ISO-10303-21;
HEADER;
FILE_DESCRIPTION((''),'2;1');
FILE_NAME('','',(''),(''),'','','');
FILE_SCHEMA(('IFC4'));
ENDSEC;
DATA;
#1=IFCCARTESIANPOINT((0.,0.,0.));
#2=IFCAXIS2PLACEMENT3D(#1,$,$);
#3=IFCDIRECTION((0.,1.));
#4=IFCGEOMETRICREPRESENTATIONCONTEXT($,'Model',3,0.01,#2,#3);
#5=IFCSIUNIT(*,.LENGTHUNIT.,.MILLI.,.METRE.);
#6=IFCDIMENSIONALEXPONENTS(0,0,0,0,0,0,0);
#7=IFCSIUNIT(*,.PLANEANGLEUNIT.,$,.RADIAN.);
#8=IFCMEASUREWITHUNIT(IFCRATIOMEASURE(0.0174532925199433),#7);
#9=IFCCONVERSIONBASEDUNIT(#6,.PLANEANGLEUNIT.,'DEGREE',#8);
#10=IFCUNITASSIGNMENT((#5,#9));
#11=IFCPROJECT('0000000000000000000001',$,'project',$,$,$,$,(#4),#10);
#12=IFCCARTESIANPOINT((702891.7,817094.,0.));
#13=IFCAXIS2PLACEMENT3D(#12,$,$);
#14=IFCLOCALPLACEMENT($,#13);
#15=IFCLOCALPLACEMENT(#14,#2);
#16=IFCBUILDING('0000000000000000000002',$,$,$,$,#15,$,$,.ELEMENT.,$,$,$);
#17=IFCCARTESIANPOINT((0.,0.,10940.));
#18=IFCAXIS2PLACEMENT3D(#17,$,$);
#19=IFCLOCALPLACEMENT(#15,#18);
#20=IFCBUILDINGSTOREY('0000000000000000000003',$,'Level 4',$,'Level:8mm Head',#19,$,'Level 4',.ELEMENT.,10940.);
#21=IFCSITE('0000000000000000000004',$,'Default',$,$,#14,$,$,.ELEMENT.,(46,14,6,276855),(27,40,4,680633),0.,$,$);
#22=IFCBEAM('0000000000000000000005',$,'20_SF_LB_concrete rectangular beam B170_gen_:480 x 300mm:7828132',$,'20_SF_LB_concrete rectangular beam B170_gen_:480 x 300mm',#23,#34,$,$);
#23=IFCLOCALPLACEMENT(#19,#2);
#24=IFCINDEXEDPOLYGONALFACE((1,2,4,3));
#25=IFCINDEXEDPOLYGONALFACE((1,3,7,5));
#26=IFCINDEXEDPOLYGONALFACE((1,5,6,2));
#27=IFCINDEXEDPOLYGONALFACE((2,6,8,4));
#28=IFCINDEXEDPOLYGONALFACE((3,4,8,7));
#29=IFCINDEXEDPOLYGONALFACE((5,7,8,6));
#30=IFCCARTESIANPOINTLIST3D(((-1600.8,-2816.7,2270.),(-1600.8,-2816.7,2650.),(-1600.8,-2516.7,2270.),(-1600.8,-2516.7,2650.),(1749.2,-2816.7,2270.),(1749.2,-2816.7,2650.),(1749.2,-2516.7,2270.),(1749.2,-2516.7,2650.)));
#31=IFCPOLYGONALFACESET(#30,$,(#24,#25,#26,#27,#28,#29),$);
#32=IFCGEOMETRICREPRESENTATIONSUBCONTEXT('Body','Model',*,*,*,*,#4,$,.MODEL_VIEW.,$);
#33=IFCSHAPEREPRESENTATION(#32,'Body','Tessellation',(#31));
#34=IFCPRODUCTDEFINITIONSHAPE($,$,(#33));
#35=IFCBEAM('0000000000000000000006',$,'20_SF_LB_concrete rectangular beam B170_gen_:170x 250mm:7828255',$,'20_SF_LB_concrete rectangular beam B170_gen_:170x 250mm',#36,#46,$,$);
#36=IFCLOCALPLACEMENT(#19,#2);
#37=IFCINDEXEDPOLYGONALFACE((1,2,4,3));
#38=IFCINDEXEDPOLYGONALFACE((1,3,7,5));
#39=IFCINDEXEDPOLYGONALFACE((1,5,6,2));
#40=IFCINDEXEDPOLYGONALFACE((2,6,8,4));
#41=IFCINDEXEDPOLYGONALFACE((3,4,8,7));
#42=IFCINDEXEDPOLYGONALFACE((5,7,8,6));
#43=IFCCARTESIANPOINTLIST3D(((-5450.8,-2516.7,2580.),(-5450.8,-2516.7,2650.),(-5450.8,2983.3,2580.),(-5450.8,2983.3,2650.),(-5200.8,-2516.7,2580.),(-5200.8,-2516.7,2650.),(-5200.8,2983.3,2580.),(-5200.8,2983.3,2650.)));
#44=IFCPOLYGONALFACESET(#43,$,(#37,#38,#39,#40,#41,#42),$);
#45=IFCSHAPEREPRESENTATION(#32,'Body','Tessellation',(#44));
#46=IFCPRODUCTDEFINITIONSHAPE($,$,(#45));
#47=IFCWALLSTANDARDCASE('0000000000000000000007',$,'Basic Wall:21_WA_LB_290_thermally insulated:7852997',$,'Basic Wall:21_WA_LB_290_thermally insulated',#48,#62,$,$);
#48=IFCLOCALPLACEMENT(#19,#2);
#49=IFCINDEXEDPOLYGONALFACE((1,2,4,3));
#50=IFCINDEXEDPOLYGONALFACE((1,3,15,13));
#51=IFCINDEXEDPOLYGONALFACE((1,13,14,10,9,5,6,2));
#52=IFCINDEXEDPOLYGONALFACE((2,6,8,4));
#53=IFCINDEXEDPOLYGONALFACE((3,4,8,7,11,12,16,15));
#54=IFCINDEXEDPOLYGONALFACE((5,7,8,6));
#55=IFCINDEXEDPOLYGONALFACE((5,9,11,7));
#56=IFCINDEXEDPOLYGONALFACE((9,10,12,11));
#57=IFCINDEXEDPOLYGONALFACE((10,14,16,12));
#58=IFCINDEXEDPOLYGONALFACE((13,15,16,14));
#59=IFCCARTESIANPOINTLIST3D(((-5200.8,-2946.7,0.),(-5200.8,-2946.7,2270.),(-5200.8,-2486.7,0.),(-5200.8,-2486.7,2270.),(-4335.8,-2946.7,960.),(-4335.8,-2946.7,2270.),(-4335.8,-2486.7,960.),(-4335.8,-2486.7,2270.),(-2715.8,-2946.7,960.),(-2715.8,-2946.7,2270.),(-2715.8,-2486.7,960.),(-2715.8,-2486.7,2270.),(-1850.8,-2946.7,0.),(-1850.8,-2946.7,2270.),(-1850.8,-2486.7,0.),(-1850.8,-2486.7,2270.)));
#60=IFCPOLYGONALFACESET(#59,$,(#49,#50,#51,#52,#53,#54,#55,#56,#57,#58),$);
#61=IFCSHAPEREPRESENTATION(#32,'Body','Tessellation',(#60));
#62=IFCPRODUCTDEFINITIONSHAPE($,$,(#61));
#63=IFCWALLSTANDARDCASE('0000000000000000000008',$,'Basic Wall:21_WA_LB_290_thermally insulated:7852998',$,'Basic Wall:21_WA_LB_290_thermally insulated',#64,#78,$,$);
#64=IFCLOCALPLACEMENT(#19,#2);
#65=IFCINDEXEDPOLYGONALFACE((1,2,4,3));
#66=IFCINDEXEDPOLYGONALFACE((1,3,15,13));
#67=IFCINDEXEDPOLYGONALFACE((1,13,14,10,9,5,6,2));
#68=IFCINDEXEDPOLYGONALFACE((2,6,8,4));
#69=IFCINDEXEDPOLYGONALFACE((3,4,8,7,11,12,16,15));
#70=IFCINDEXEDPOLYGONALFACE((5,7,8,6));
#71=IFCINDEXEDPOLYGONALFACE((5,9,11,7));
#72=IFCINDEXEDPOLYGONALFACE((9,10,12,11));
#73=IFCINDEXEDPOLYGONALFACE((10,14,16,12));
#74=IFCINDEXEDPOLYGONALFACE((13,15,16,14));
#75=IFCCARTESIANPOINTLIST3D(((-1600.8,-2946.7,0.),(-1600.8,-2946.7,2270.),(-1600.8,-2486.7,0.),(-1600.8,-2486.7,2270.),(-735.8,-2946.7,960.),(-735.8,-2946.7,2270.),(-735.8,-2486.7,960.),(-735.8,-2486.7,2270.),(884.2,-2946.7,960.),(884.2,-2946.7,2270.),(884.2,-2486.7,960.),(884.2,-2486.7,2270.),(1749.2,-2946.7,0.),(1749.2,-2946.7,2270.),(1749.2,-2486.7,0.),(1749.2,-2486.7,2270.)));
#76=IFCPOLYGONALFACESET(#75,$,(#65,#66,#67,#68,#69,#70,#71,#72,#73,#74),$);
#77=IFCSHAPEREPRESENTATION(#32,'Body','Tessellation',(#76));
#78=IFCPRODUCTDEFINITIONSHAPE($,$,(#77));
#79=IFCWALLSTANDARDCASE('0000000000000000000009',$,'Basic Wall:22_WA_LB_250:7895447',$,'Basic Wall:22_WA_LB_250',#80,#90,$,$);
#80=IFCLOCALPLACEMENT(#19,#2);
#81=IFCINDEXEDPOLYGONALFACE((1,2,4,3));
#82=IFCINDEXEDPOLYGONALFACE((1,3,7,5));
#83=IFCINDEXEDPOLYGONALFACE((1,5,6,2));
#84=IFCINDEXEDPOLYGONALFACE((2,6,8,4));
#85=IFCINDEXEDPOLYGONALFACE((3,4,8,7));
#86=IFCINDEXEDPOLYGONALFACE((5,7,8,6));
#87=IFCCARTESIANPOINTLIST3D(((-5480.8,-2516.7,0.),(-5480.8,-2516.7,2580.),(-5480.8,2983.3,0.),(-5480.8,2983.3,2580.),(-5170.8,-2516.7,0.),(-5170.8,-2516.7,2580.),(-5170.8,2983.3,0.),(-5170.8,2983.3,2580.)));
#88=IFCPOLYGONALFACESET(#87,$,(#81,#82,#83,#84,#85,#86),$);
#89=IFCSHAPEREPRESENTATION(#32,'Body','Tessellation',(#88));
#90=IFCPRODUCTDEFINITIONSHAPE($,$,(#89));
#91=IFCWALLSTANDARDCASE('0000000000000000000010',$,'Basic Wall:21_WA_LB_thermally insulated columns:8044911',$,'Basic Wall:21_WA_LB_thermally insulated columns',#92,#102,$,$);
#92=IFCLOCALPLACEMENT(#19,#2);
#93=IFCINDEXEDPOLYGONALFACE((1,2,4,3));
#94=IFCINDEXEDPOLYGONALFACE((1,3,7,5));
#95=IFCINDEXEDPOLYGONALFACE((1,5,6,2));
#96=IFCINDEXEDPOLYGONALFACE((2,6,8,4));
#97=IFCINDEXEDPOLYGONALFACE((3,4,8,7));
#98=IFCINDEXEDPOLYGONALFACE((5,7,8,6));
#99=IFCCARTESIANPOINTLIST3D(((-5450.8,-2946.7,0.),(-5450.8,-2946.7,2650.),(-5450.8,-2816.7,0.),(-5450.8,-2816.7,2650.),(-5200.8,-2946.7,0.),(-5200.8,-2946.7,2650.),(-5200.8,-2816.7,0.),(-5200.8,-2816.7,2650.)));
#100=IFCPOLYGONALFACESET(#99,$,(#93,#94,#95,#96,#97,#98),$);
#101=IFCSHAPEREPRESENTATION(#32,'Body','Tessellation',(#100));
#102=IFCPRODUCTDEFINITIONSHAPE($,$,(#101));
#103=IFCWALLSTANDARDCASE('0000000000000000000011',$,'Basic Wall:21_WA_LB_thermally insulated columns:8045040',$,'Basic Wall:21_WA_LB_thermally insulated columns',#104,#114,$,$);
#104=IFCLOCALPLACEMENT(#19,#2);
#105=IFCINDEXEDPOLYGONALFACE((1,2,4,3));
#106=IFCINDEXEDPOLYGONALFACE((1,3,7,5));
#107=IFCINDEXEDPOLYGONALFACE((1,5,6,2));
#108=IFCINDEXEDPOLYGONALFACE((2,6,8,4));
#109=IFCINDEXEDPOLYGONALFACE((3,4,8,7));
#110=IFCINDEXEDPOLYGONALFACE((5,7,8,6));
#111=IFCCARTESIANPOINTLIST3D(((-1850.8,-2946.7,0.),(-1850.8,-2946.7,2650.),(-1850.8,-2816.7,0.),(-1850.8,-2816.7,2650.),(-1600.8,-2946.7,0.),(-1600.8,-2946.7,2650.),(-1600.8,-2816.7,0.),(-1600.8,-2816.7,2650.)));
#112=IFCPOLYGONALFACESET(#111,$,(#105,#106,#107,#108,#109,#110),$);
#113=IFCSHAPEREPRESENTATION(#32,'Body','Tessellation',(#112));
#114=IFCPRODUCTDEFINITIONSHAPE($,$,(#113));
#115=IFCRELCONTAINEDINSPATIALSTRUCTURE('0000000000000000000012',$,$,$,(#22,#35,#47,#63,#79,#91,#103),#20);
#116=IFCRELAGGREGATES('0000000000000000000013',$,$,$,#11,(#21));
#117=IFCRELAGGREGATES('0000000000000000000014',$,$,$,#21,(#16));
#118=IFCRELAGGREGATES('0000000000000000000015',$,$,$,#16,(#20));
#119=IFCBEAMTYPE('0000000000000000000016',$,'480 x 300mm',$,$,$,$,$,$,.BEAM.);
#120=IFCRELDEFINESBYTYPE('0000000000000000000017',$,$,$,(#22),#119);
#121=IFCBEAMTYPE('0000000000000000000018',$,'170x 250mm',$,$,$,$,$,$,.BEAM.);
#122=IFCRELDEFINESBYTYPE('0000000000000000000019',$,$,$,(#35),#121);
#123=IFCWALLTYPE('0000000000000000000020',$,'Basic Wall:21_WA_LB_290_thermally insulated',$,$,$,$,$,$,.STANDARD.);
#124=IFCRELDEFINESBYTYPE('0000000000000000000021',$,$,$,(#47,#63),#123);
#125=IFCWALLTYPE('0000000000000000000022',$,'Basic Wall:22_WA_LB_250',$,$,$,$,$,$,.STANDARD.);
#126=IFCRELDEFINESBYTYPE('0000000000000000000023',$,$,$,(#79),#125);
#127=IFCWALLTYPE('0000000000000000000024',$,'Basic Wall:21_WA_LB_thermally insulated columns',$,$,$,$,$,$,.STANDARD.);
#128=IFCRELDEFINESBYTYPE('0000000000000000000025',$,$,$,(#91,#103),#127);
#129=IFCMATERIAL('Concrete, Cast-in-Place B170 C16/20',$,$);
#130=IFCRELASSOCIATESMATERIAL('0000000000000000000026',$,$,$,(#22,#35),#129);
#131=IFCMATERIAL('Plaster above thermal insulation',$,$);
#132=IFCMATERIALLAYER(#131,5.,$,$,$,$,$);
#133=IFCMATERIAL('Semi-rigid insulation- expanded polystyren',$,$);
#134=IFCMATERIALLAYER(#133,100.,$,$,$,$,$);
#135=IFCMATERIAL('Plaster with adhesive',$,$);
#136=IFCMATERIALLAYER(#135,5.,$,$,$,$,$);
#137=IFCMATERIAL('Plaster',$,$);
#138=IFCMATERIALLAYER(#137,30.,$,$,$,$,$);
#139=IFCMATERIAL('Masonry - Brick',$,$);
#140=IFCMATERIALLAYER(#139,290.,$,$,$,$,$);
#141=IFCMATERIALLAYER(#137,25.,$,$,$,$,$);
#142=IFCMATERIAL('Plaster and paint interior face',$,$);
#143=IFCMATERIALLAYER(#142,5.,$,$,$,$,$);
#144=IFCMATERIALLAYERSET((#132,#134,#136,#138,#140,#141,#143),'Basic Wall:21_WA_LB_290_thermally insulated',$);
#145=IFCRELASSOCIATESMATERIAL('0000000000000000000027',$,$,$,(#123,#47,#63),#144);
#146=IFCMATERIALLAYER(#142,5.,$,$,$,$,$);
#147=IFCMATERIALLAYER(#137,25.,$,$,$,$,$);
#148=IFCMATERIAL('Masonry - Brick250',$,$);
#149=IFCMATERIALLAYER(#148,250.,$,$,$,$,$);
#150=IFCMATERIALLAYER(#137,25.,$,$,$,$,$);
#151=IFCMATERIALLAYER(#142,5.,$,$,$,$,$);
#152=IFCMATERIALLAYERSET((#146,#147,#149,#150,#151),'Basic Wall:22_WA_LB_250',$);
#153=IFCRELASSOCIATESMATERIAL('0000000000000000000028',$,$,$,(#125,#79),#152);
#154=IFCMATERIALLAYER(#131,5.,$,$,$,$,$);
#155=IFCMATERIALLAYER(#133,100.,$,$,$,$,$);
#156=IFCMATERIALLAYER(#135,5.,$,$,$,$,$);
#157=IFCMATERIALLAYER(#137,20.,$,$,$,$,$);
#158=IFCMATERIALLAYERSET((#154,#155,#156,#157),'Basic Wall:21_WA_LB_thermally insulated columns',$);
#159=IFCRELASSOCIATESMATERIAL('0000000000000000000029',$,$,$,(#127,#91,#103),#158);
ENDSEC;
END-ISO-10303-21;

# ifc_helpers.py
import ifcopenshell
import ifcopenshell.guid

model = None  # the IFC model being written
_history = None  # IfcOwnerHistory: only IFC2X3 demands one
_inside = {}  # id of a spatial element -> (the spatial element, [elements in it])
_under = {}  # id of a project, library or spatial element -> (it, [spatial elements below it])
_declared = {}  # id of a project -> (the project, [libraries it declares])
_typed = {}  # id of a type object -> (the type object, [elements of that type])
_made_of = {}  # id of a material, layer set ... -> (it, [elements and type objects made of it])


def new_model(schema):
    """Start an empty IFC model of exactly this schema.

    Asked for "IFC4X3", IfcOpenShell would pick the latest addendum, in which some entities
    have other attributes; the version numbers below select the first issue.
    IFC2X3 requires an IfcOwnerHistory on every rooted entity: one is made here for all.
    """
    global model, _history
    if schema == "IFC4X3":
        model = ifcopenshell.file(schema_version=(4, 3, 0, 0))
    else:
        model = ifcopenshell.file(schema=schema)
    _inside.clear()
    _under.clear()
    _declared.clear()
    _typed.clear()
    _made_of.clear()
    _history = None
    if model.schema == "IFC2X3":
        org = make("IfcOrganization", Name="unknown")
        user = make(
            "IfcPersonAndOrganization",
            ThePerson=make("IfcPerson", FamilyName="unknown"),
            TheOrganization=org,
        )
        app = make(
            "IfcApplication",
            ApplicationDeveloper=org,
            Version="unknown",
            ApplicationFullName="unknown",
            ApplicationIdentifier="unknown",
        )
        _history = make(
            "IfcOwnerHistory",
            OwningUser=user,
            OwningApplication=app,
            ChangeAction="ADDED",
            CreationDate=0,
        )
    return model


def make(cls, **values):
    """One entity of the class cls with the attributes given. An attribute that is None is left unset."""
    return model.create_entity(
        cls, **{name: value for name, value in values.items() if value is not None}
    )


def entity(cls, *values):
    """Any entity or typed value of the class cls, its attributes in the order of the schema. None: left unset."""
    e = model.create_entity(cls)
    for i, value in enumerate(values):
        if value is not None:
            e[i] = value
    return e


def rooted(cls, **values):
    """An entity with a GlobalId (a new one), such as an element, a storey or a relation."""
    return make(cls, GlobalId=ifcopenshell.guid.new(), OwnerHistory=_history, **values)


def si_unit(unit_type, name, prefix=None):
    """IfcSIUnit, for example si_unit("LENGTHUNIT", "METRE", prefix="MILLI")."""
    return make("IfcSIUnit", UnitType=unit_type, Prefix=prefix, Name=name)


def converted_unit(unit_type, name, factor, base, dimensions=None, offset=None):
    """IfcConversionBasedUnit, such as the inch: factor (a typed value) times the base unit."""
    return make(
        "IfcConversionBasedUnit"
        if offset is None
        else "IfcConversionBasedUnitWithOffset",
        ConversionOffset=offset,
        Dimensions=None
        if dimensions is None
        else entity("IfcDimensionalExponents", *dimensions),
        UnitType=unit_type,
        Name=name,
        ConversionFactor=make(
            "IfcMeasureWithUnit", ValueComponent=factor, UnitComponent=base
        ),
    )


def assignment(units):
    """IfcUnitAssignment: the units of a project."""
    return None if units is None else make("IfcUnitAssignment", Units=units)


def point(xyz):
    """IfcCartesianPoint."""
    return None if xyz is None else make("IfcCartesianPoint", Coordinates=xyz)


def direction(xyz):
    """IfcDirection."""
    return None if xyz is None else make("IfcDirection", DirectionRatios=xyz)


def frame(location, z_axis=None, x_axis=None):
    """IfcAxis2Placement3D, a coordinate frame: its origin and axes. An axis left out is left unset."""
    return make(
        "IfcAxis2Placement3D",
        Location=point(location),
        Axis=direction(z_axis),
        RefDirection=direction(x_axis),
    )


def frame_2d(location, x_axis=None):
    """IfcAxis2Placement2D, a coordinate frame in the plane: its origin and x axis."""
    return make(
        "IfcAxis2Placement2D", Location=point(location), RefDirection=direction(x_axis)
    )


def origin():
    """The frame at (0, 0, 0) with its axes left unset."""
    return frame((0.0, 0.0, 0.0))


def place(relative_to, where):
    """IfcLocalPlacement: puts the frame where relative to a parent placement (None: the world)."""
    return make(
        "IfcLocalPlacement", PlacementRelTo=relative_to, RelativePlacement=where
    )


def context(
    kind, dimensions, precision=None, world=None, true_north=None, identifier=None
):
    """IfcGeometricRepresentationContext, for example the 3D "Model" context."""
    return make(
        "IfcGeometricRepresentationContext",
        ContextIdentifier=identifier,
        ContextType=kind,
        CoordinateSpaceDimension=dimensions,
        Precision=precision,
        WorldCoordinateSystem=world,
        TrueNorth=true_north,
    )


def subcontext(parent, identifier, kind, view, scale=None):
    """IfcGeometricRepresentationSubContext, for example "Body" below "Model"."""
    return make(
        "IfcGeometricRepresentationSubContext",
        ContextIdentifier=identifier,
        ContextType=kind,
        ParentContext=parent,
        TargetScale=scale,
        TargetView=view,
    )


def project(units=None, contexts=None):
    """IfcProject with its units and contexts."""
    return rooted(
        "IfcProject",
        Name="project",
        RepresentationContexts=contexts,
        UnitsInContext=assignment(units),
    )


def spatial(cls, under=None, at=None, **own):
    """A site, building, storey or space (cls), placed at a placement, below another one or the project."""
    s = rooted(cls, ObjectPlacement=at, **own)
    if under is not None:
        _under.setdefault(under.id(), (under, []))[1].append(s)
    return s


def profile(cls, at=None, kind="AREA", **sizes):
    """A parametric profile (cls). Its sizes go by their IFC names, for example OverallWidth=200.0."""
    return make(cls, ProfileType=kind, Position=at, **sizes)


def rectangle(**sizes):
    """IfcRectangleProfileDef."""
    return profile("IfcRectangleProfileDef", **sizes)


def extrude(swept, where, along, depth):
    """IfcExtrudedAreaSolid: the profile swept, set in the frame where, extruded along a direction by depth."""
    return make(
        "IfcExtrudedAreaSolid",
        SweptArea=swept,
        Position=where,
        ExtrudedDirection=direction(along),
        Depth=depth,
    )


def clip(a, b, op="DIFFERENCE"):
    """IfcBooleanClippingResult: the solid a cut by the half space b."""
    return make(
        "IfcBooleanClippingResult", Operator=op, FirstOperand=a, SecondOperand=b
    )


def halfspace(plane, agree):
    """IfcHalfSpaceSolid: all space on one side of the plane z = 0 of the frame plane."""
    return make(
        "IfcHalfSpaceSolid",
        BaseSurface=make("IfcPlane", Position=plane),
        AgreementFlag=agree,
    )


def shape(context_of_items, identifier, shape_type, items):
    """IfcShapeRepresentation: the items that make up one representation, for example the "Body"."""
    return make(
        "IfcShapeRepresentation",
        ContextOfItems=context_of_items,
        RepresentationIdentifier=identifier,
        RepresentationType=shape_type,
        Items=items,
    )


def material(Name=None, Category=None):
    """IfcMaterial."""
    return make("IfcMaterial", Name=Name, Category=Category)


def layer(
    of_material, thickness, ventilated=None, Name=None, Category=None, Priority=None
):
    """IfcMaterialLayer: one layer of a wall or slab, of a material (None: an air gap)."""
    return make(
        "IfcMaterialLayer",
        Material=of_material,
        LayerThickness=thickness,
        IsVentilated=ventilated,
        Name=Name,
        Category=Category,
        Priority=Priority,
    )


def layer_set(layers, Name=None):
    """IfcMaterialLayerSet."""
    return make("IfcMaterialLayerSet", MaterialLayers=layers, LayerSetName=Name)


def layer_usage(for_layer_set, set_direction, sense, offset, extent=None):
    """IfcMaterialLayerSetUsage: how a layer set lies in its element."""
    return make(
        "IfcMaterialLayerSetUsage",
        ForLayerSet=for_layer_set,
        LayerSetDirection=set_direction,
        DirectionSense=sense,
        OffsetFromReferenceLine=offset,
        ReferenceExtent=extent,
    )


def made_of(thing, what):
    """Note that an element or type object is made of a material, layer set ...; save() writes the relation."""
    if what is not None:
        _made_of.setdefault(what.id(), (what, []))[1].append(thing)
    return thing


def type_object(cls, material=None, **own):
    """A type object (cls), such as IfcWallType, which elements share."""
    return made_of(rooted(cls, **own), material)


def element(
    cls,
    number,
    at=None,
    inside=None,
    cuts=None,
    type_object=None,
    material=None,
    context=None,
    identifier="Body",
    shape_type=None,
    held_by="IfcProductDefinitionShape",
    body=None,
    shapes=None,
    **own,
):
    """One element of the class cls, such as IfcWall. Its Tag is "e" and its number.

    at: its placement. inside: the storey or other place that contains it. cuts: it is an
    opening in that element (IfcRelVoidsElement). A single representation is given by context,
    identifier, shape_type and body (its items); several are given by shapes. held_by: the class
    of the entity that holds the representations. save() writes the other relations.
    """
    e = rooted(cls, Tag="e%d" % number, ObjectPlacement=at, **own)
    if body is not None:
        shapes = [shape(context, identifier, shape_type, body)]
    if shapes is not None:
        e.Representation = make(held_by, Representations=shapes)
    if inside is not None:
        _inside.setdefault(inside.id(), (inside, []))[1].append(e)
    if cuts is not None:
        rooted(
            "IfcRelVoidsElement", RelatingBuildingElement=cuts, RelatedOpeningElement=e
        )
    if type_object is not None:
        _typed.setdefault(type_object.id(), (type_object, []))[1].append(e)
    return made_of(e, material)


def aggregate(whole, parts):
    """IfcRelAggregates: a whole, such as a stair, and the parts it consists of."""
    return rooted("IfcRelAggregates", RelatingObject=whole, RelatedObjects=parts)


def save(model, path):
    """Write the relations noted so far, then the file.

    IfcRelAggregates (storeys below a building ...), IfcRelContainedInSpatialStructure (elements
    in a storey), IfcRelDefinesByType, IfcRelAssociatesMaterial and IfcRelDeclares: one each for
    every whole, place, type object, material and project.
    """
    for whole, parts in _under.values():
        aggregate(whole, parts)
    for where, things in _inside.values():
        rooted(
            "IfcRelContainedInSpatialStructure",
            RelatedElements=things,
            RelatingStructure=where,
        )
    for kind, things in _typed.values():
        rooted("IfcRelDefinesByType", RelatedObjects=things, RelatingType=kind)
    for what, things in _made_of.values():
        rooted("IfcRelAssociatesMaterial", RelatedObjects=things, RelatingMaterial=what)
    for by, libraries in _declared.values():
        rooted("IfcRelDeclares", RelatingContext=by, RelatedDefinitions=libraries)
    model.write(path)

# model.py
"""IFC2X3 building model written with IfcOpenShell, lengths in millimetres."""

from ifc_helpers import new_model, entity, si_unit, converted_unit, direction, frame, frame_2d, origin, place, context, subcontext, project, spatial, rectangle, extrude, clip, halfspace, material, layer, layer_set, layer_usage, type_object, element, save


model = new_model("IFC2X3")

# Units and contexts
model_context = context("Model", 3, precision=0.01, world=origin(), true_north=direction((0.0, 1.0)))
body_context = subcontext(model_context, "Body", "Model", "MODEL_VIEW")
ifc_project = project(units=[si_unit("LENGTHUNIT", "METRE", prefix="MILLI"), converted_unit("PLANEANGLEUNIT", "DEGREE", entity("IfcRatioMeasure", 0.0174532925199433), si_unit("PLANEANGLEUNIT", "RADIAN"), dimensions=[0, 0, 0, 0, 0, 0, 0])], contexts=[model_context])

# Site, building, storey
site_placement = place(None, frame((702891.7, 817094.0, 0.0)))
site = spatial("IfcSite", under=ifc_project, at=site_placement, Name="Default", CompositionType="ELEMENT", RefLatitude=(46, 14, 6, 276855), RefLongitude=(27, 40, 4, 680633), RefElevation=0.0)
building_placement = place(site_placement, origin())
building = spatial("IfcBuilding", under=site, at=building_placement, CompositionType="ELEMENT")
storey_placement = place(building_placement, frame((0.0, 0.0, 10940.0)))
storey = spatial("IfcBuildingStorey", under=building, at=storey_placement, Name="Level 4", ObjectType="Level:8mm Head", LongName="Level 4", CompositionType="ELEMENT", Elevation=10940.0)

# Shared definitions
ifc_material_1 = material(Name="Concrete, Cast-in-Place B170 C16/20")

# Beams
beam_type_1 = type_object("IfcBeamType", Name="480 x 300mm", PredefinedType="BEAM")
beam_1_placement = place(storey_placement, frame((-1600.8, -2666.7, 0.0)))
element("IfcBeam", 1, at=beam_1_placement, inside=storey, type_object=beam_type_1, material=ifc_material_1, Name="20_SF_LB_concrete rectangular beam B170_gen_:480 x 300mm:7828132", ObjectType="20_SF_LB_concrete rectangular beam B170_gen_:480 x 300mm", context=body_context, shape_type="SweptSolid", body=[
    extrude(rectangle(XDim=380.0, YDim=300.0, at=frame_2d((0.0, 0.0), x_axis=(1.0, 0.0))), frame((0.0, 0.0, 2460.0), z_axis=(1.0, 0.0, 0.0), x_axis=(0.0, 0.0, -1.0)), (0.0, 0.0, 1.0), 3350.0),
])
beam_type_2 = type_object("IfcBeamType", Name="170x 250mm", PredefinedType="BEAM")
beam_2_placement = place(storey_placement, frame((-5325.8, -2516.7, 0.0), z_axis=(0.0, 0.0, 1.0), x_axis=(0.0, 1.0, 0.0)))
element("IfcBeam", 2, at=beam_2_placement, inside=storey, type_object=beam_type_2, material=ifc_material_1, Name="20_SF_LB_concrete rectangular beam B170_gen_:170x 250mm:7828255", ObjectType="20_SF_LB_concrete rectangular beam B170_gen_:170x 250mm", context=body_context, shape_type="SweptSolid", body=[
    extrude(rectangle(XDim=70.0, YDim=250.0, at=frame_2d((0.0, 0.0), x_axis=(1.0, 0.0))), frame((0.0, 0.0, 2615.0), z_axis=(1.0, 0.0, 0.0), x_axis=(0.0, 0.0, -1.0)), (0.0, 0.0, 1.0), 5500.0),
])

# Walls, openings
ifc_material_2 = material(Name="Plaster above thermal insulation")
ifc_layer_1 = layer(ifc_material_2, 5.0)
ifc_material_3 = material(Name="Semi-rigid insulation- expanded polystyren")
ifc_layer_2 = layer(ifc_material_3, 100.0)
ifc_material_4 = material(Name="Plaster with adhesive")
ifc_layer_3 = layer(ifc_material_4, 5.0)
ifc_material_5 = material(Name="Plaster")
ifc_layer_4 = layer(ifc_material_5, 30.0)
ifc_material_6 = material(Name="Masonry - Brick")
ifc_layer_5 = layer(ifc_material_6, 290.0)
ifc_layer_6 = layer(ifc_material_5, 25.0)
ifc_material_7 = material(Name="Plaster and paint interior face")
ifc_layer_7 = layer(ifc_material_7, 5.0)
ifc_layer_set_1 = layer_set([ifc_layer_1, ifc_layer_2, ifc_layer_3, ifc_layer_4, ifc_layer_5, ifc_layer_6, ifc_layer_7], Name="Basic Wall:21_WA_LB_290_thermally insulated")
ifc_layer_usage_1 = layer_usage(ifc_layer_set_1, "AXIS2", "POSITIVE", -230.0)
wall_type_1 = type_object("IfcWallType", Name="Basic Wall:21_WA_LB_290_thermally insulated", PredefinedType="STANDARD", material=ifc_layer_set_1)
wall_1_placement = place(storey_placement, frame((-5200.8, -2716.7, 0.0)))
wall_1 = element("IfcWallStandardCase", 3, at=wall_1_placement, inside=storey, type_object=wall_type_1, material=ifc_layer_usage_1, Name="Basic Wall:21_WA_LB_290_thermally insulated:7852997", ObjectType="Basic Wall:21_WA_LB_290_thermally insulated", context=body_context, shape_type="SweptSolid", body=[
    extrude(rectangle(XDim=3350.0, YDim=460.0, at=frame_2d((1675.0, 0.0), x_axis=(-1.0, 0.0))), origin(), (0.0, 0.0, 1.0), 2270.0),
])
opening_1_placement = place(wall_1_placement, frame((2485.0, 230.0, 960.0)))
element("IfcOpeningElement", 4, at=opening_1_placement, cuts=wall_1, ObjectType="Opening", context=body_context, shape_type="SweptSolid", body=[
    extrude(rectangle(XDim=1320.0, YDim=1620.0, at=frame_2d((660.0, 810.0), x_axis=(1.0, 0.0))), frame((0.0, 0.0, 0.0), z_axis=(0.0, -1.0, 0.0), x_axis=(0.0, 0.0, 1.0)), (0.0, 0.0, 1.0), 460.0),
])
ifc_layer_usage_2 = layer_usage(ifc_layer_set_1, "AXIS2", "POSITIVE", -230.0)
wall_2_placement = place(storey_placement, frame((-1600.8, -2716.7, 0.0)))
wall_2 = element("IfcWallStandardCase", 5, at=wall_2_placement, inside=storey, type_object=wall_type_1, material=ifc_layer_usage_2, Name="Basic Wall:21_WA_LB_290_thermally insulated:7852998", ObjectType="Basic Wall:21_WA_LB_290_thermally insulated", context=body_context, shape_type="SweptSolid", body=[
    extrude(rectangle(XDim=3350.0, YDim=460.0, at=frame_2d((1675.0, 0.0), x_axis=(-1.0, 0.0))), origin(), (0.0, 0.0, 1.0), 2270.0),
])
opening_2_placement = place(wall_2_placement, frame((2485.0, 230.0, 960.0)))
element("IfcOpeningElement", 6, at=opening_2_placement, cuts=wall_2, ObjectType="Opening", context=body_context, shape_type="SweptSolid", body=[
    extrude(rectangle(XDim=1320.0, YDim=1620.0, at=frame_2d((660.0, 810.0), x_axis=(1.0, 0.0))), frame((0.0, 0.0, 0.0), z_axis=(0.0, -1.0, 0.0), x_axis=(0.0, 0.0, 1.0)), (0.0, 0.0, 1.0), 460.0),
])

# Walls
ifc_layer_8 = layer(ifc_material_7, 5.0)
ifc_layer_9 = layer(ifc_material_5, 25.0)
ifc_material_8 = material(Name="Masonry - Brick250")
ifc_layer_10 = layer(ifc_material_8, 250.0)
ifc_layer_11 = layer(ifc_material_5, 25.0)
ifc_layer_12 = layer(ifc_material_7, 5.0)
ifc_layer_set_2 = layer_set([ifc_layer_8, ifc_layer_9, ifc_layer_10, ifc_layer_11, ifc_layer_12], Name="Basic Wall:22_WA_LB_250")
ifc_layer_usage_3 = layer_usage(ifc_layer_set_2, "AXIS2", "NEGATIVE", 155.0)
wall_type_2 = type_object("IfcWallType", Name="Basic Wall:22_WA_LB_250", PredefinedType="STANDARD", material=ifc_layer_set_2)
wall_3_placement = place(storey_placement, frame((-5325.8, -2516.7, 0.0), z_axis=(0.0, 0.0, 1.0), x_axis=(0.0, 1.0, 0.0)))
element("IfcWallStandardCase", 7, at=wall_3_placement, inside=storey, type_object=wall_type_2, material=ifc_layer_usage_3, Name="Basic Wall:22_WA_LB_250:7895447", ObjectType="Basic Wall:22_WA_LB_250", context=body_context, shape_type="SweptSolid", body=[
    extrude(rectangle(XDim=5500.0, YDim=310.0, at=frame_2d((2750.0, 0.0), x_axis=(-1.0, 0.0))), origin(), (0.0, 0.0, 1.0), 2580.0),
])
ifc_layer_13 = layer(ifc_material_2, 5.0)
ifc_layer_14 = layer(ifc_material_3, 100.0)
ifc_layer_15 = layer(ifc_material_4, 5.0)
ifc_layer_16 = layer(ifc_material_5, 20.0)
ifc_layer_set_3 = layer_set([ifc_layer_13, ifc_layer_14, ifc_layer_15, ifc_layer_16], Name="Basic Wall:21_WA_LB_thermally insulated columns")
ifc_layer_usage_4 = layer_usage(ifc_layer_set_3, "AXIS2", "NEGATIVE", 65.0)
wall_type_3 = type_object("IfcWallType", Name="Basic Wall:21_WA_LB_thermally insulated columns", PredefinedType="STANDARD", material=ifc_layer_set_3)
wall_4_placement = place(storey_placement, frame((-5200.8, -2881.7, 0.0), z_axis=(0.0, 0.0, 1.0), x_axis=(-1.0, 0.0, 0.0)))
element("IfcWallStandardCase", 8, at=wall_4_placement, inside=storey, type_object=wall_type_3, material=ifc_layer_usage_4, Name="Basic Wall:21_WA_LB_thermally insulated columns:8044911", ObjectType="Basic Wall:21_WA_LB_thermally insulated columns", context=body_context, shape_type="Clipping", body=[
    clip(extrude(rectangle(XDim=250.0, YDim=130.0, at=frame_2d((125.0, 0.0), x_axis=(-1.0, 0.0))), origin(), (0.0, 0.0, 1.0), 2650.0), halfspace(frame((0.0, 0.0, -11000.0)), True)),
])
ifc_layer_usage_5 = layer_usage(ifc_layer_set_3, "AXIS2", "NEGATIVE", 65.0)
wall_5_placement = place(storey_placement, frame((-1600.8, -2881.7, 0.0), z_axis=(0.0, 0.0, 1.0), x_axis=(-1.0, 0.0, 0.0)))
element("IfcWallStandardCase", 9, at=wall_5_placement, inside=storey, type_object=wall_type_3, material=ifc_layer_usage_5, Name="Basic Wall:21_WA_LB_thermally insulated columns:8045040", ObjectType="Basic Wall:21_WA_LB_thermally insulated columns", context=body_context, shape_type="Clipping", body=[
    clip(extrude(rectangle(XDim=250.0, YDim=130.0, at=frame_2d((125.0, 0.0), x_axis=(-1.0, 0.0))), origin(), (0.0, 0.0, 1.0), 2650.0), halfspace(frame((0.0, 0.0, -11000.0)), True)),
])

save(model, "model.ifc")
